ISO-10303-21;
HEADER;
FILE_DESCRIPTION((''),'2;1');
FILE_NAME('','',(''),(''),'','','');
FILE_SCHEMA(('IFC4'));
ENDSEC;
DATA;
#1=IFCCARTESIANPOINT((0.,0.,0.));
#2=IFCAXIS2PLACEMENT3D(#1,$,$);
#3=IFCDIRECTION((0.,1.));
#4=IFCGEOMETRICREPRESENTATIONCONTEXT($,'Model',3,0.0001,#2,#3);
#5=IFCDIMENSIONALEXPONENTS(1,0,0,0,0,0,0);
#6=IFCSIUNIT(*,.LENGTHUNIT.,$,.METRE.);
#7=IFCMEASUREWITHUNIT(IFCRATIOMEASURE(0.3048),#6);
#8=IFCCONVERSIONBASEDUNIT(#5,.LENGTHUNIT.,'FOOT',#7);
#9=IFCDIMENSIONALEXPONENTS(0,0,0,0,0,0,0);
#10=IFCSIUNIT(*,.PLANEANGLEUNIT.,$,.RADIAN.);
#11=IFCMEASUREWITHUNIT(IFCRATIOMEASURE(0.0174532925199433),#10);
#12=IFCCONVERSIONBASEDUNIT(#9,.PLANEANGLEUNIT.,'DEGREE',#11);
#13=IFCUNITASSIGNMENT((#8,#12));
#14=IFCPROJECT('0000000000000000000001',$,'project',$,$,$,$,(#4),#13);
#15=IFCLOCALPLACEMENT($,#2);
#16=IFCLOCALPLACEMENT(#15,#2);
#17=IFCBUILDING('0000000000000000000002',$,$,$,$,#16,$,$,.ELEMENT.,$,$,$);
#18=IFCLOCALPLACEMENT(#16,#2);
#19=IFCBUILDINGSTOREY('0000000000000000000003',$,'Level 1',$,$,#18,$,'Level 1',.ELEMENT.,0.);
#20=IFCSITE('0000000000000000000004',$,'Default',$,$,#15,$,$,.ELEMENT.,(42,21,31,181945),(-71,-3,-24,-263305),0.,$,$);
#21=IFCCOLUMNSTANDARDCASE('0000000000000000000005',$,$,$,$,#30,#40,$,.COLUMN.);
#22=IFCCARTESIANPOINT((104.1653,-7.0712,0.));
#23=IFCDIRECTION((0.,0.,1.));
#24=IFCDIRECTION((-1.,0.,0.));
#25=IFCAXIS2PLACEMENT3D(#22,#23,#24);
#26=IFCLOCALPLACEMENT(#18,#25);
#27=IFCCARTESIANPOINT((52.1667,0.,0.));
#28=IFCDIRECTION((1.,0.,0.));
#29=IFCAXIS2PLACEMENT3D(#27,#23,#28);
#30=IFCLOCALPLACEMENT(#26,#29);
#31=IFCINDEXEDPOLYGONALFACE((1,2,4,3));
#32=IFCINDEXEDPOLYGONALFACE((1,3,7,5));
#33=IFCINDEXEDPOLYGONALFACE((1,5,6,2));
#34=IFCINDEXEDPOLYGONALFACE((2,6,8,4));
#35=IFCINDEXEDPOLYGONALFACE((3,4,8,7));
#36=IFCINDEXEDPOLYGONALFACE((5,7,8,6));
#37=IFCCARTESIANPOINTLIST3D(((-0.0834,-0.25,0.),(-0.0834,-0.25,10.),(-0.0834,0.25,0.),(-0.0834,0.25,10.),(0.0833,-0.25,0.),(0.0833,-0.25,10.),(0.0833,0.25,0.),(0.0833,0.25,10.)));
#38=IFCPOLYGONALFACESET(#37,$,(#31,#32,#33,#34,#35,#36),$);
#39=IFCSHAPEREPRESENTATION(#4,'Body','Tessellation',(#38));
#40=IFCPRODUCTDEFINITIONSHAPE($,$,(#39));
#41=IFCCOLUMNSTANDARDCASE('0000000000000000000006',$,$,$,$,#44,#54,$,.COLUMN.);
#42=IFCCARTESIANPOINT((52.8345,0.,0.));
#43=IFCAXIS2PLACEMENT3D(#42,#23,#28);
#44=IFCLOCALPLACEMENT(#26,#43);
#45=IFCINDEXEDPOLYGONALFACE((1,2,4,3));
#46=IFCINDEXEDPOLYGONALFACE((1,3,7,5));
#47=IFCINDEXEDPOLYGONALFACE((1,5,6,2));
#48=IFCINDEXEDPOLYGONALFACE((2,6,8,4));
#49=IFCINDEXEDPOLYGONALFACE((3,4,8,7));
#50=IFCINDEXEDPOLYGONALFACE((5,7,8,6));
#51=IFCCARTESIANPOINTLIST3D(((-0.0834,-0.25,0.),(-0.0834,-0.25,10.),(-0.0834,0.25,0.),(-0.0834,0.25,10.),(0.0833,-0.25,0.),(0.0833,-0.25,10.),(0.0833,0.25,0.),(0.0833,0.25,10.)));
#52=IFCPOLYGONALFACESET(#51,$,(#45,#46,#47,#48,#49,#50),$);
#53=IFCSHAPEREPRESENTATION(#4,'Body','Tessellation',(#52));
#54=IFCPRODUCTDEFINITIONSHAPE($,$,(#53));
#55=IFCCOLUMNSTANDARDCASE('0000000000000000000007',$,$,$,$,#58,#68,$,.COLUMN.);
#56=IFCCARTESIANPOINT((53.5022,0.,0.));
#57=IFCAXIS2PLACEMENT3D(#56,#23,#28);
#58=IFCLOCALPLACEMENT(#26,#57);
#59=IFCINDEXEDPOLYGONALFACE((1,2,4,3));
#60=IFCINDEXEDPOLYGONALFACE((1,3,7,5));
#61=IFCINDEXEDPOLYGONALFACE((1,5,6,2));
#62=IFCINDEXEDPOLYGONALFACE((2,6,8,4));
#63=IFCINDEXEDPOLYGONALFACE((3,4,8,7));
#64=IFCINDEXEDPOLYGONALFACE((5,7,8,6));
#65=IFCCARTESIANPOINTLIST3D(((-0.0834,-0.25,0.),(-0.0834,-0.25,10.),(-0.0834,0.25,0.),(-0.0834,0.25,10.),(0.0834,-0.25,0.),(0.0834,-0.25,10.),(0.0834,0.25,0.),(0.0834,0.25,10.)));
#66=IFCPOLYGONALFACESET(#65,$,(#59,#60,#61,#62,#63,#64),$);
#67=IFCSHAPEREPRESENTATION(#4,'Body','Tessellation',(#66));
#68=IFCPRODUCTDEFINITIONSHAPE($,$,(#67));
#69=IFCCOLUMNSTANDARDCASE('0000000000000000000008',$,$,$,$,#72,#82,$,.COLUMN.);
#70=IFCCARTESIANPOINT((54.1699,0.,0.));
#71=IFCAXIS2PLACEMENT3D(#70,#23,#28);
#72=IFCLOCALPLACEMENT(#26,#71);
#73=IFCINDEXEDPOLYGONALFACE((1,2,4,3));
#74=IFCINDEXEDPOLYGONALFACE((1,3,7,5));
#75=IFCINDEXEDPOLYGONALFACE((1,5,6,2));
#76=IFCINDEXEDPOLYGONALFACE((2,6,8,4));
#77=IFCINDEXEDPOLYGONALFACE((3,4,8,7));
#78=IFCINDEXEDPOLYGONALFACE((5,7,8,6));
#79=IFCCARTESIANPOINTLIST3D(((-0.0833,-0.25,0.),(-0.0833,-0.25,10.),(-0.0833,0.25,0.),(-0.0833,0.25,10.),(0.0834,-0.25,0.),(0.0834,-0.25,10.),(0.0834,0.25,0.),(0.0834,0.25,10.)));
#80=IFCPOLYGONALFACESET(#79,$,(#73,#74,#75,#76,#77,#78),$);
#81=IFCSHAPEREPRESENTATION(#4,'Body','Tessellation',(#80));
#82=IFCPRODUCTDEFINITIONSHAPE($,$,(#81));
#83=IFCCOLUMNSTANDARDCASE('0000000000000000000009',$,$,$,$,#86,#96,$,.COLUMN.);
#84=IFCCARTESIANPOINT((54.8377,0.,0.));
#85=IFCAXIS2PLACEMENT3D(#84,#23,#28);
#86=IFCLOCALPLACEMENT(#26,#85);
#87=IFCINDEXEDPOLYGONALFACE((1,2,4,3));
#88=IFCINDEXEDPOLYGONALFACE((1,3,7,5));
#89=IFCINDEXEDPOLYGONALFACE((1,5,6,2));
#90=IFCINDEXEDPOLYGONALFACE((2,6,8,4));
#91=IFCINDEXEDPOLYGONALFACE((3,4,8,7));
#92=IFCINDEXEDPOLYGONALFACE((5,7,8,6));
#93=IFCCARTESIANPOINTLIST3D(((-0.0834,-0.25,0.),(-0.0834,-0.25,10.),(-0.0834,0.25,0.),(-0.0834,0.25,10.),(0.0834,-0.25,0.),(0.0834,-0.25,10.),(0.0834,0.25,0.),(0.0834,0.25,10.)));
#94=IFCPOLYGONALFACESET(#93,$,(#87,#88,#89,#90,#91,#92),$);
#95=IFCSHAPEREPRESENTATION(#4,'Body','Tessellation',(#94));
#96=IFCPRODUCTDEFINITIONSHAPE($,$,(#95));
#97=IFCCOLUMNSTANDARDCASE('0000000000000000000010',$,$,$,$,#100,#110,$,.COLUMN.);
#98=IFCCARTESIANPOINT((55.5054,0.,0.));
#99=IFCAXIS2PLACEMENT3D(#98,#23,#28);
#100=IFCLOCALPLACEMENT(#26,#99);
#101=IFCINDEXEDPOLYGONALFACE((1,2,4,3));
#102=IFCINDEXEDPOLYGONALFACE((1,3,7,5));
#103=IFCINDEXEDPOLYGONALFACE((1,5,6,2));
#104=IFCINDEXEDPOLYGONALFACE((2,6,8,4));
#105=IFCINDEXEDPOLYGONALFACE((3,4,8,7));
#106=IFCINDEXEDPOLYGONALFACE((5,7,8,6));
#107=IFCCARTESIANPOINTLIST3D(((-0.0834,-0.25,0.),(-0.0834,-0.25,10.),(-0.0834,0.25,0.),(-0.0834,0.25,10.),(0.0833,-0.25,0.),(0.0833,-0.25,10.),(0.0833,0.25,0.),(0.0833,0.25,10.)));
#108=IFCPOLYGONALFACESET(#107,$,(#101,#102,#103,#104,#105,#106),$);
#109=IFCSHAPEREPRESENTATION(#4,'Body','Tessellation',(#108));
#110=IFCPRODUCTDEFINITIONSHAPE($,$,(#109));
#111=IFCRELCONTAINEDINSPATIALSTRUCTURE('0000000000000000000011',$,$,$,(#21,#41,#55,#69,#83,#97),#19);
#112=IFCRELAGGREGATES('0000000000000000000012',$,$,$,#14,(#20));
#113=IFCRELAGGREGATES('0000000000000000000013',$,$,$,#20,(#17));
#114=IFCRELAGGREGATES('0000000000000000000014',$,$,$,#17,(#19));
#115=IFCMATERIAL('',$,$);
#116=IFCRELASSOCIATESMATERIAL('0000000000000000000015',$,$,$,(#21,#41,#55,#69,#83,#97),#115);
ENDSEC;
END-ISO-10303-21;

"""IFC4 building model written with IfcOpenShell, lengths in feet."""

from ifc_helpers import new_model, entity, si_unit, converted_unit, direction, frame, origin, place, context, project, spatial, rectangle, extrude, material, element, save


model = new_model("IFC4")

# Units and contexts
model_context = context("Model", 3, precision=0.0001, world=origin(), true_north=direction((0.0, 1.0)))
ifc_project = project(units=[converted_unit("LENGTHUNIT", "FOOT", entity("IfcRatioMeasure", 0.3048), si_unit("LENGTHUNIT", "METRE"), dimensions=[1, 0, 0, 0, 0, 0, 0]), converted_unit("PLANEANGLEUNIT", "DEGREE", entity("IfcRatioMeasure", 0.0174532925199433), si_unit("PLANEANGLEUNIT", "RADIAN"), dimensions=[0, 0, 0, 0, 0, 0, 0])], contexts=[model_context])

# Site, building, storey
site_placement = place(None, origin())
site = spatial("IfcSite", under=ifc_project, at=site_placement, Name="Default", CompositionType="ELEMENT", RefLatitude=(42, 21, 31, 181945), RefLongitude=(-71, -3, -24, -263305), RefElevation=0.0)
building_placement = place(site_placement, origin())
building = spatial("IfcBuilding", under=site, at=building_placement, CompositionType="ELEMENT")
storey_placement = place(building_placement, origin())
storey = spatial("IfcBuildingStorey", under=building, at=storey_placement, Name="Level 1", LongName="Level 1", CompositionType="ELEMENT", Elevation=0.0)

# Columns
ifc_material_1 = material(Name="")
placement_1 = place(storey_placement, frame((104.1653, -7.0712, 0.0), z_axis=(0.0, 0.0, 1.0), x_axis=(-1.0, 0.0, 0.0)))
for number, where, z_axis, x_axis in (
    (1, (52.1667, 0.0, 0.0), (0.0, 0.0, 1.0), (1.0, 0.0, 0.0)),
    (2, (52.8345, 0.0, 0.0), (0.0, 0.0, 1.0), (1.0, 0.0, 0.0)),
    (3, (53.5022, 0.0, 0.0), (0.0, 0.0, 1.0), (1.0, 0.0, 0.0)),
    (4, (54.1699, 0.0, 0.0), (0.0, 0.0, 1.0), (1.0, 0.0, 0.0)),
    (5, (54.8377, 0.0, 0.0), (0.0, 0.0, 1.0), (1.0, 0.0, 0.0)),
    (6, (55.5054, 0.0, 0.0), (0.0, 0.0, 1.0), (1.0, 0.0, 0.0)),
):
    element("IfcColumnStandardCase", number, at=place(placement_1, frame(where, z_axis=z_axis, x_axis=x_axis)), inside=storey, material=ifc_material_1, PredefinedType="COLUMN", context=model_context, shape_type="SweptSolid", body=[
        extrude(rectangle(XDim=0.1667, YDim=0.5), origin(), (0.0, 0.0, 1.0), 10.0),
    ])

save(model, "model.ifc")
